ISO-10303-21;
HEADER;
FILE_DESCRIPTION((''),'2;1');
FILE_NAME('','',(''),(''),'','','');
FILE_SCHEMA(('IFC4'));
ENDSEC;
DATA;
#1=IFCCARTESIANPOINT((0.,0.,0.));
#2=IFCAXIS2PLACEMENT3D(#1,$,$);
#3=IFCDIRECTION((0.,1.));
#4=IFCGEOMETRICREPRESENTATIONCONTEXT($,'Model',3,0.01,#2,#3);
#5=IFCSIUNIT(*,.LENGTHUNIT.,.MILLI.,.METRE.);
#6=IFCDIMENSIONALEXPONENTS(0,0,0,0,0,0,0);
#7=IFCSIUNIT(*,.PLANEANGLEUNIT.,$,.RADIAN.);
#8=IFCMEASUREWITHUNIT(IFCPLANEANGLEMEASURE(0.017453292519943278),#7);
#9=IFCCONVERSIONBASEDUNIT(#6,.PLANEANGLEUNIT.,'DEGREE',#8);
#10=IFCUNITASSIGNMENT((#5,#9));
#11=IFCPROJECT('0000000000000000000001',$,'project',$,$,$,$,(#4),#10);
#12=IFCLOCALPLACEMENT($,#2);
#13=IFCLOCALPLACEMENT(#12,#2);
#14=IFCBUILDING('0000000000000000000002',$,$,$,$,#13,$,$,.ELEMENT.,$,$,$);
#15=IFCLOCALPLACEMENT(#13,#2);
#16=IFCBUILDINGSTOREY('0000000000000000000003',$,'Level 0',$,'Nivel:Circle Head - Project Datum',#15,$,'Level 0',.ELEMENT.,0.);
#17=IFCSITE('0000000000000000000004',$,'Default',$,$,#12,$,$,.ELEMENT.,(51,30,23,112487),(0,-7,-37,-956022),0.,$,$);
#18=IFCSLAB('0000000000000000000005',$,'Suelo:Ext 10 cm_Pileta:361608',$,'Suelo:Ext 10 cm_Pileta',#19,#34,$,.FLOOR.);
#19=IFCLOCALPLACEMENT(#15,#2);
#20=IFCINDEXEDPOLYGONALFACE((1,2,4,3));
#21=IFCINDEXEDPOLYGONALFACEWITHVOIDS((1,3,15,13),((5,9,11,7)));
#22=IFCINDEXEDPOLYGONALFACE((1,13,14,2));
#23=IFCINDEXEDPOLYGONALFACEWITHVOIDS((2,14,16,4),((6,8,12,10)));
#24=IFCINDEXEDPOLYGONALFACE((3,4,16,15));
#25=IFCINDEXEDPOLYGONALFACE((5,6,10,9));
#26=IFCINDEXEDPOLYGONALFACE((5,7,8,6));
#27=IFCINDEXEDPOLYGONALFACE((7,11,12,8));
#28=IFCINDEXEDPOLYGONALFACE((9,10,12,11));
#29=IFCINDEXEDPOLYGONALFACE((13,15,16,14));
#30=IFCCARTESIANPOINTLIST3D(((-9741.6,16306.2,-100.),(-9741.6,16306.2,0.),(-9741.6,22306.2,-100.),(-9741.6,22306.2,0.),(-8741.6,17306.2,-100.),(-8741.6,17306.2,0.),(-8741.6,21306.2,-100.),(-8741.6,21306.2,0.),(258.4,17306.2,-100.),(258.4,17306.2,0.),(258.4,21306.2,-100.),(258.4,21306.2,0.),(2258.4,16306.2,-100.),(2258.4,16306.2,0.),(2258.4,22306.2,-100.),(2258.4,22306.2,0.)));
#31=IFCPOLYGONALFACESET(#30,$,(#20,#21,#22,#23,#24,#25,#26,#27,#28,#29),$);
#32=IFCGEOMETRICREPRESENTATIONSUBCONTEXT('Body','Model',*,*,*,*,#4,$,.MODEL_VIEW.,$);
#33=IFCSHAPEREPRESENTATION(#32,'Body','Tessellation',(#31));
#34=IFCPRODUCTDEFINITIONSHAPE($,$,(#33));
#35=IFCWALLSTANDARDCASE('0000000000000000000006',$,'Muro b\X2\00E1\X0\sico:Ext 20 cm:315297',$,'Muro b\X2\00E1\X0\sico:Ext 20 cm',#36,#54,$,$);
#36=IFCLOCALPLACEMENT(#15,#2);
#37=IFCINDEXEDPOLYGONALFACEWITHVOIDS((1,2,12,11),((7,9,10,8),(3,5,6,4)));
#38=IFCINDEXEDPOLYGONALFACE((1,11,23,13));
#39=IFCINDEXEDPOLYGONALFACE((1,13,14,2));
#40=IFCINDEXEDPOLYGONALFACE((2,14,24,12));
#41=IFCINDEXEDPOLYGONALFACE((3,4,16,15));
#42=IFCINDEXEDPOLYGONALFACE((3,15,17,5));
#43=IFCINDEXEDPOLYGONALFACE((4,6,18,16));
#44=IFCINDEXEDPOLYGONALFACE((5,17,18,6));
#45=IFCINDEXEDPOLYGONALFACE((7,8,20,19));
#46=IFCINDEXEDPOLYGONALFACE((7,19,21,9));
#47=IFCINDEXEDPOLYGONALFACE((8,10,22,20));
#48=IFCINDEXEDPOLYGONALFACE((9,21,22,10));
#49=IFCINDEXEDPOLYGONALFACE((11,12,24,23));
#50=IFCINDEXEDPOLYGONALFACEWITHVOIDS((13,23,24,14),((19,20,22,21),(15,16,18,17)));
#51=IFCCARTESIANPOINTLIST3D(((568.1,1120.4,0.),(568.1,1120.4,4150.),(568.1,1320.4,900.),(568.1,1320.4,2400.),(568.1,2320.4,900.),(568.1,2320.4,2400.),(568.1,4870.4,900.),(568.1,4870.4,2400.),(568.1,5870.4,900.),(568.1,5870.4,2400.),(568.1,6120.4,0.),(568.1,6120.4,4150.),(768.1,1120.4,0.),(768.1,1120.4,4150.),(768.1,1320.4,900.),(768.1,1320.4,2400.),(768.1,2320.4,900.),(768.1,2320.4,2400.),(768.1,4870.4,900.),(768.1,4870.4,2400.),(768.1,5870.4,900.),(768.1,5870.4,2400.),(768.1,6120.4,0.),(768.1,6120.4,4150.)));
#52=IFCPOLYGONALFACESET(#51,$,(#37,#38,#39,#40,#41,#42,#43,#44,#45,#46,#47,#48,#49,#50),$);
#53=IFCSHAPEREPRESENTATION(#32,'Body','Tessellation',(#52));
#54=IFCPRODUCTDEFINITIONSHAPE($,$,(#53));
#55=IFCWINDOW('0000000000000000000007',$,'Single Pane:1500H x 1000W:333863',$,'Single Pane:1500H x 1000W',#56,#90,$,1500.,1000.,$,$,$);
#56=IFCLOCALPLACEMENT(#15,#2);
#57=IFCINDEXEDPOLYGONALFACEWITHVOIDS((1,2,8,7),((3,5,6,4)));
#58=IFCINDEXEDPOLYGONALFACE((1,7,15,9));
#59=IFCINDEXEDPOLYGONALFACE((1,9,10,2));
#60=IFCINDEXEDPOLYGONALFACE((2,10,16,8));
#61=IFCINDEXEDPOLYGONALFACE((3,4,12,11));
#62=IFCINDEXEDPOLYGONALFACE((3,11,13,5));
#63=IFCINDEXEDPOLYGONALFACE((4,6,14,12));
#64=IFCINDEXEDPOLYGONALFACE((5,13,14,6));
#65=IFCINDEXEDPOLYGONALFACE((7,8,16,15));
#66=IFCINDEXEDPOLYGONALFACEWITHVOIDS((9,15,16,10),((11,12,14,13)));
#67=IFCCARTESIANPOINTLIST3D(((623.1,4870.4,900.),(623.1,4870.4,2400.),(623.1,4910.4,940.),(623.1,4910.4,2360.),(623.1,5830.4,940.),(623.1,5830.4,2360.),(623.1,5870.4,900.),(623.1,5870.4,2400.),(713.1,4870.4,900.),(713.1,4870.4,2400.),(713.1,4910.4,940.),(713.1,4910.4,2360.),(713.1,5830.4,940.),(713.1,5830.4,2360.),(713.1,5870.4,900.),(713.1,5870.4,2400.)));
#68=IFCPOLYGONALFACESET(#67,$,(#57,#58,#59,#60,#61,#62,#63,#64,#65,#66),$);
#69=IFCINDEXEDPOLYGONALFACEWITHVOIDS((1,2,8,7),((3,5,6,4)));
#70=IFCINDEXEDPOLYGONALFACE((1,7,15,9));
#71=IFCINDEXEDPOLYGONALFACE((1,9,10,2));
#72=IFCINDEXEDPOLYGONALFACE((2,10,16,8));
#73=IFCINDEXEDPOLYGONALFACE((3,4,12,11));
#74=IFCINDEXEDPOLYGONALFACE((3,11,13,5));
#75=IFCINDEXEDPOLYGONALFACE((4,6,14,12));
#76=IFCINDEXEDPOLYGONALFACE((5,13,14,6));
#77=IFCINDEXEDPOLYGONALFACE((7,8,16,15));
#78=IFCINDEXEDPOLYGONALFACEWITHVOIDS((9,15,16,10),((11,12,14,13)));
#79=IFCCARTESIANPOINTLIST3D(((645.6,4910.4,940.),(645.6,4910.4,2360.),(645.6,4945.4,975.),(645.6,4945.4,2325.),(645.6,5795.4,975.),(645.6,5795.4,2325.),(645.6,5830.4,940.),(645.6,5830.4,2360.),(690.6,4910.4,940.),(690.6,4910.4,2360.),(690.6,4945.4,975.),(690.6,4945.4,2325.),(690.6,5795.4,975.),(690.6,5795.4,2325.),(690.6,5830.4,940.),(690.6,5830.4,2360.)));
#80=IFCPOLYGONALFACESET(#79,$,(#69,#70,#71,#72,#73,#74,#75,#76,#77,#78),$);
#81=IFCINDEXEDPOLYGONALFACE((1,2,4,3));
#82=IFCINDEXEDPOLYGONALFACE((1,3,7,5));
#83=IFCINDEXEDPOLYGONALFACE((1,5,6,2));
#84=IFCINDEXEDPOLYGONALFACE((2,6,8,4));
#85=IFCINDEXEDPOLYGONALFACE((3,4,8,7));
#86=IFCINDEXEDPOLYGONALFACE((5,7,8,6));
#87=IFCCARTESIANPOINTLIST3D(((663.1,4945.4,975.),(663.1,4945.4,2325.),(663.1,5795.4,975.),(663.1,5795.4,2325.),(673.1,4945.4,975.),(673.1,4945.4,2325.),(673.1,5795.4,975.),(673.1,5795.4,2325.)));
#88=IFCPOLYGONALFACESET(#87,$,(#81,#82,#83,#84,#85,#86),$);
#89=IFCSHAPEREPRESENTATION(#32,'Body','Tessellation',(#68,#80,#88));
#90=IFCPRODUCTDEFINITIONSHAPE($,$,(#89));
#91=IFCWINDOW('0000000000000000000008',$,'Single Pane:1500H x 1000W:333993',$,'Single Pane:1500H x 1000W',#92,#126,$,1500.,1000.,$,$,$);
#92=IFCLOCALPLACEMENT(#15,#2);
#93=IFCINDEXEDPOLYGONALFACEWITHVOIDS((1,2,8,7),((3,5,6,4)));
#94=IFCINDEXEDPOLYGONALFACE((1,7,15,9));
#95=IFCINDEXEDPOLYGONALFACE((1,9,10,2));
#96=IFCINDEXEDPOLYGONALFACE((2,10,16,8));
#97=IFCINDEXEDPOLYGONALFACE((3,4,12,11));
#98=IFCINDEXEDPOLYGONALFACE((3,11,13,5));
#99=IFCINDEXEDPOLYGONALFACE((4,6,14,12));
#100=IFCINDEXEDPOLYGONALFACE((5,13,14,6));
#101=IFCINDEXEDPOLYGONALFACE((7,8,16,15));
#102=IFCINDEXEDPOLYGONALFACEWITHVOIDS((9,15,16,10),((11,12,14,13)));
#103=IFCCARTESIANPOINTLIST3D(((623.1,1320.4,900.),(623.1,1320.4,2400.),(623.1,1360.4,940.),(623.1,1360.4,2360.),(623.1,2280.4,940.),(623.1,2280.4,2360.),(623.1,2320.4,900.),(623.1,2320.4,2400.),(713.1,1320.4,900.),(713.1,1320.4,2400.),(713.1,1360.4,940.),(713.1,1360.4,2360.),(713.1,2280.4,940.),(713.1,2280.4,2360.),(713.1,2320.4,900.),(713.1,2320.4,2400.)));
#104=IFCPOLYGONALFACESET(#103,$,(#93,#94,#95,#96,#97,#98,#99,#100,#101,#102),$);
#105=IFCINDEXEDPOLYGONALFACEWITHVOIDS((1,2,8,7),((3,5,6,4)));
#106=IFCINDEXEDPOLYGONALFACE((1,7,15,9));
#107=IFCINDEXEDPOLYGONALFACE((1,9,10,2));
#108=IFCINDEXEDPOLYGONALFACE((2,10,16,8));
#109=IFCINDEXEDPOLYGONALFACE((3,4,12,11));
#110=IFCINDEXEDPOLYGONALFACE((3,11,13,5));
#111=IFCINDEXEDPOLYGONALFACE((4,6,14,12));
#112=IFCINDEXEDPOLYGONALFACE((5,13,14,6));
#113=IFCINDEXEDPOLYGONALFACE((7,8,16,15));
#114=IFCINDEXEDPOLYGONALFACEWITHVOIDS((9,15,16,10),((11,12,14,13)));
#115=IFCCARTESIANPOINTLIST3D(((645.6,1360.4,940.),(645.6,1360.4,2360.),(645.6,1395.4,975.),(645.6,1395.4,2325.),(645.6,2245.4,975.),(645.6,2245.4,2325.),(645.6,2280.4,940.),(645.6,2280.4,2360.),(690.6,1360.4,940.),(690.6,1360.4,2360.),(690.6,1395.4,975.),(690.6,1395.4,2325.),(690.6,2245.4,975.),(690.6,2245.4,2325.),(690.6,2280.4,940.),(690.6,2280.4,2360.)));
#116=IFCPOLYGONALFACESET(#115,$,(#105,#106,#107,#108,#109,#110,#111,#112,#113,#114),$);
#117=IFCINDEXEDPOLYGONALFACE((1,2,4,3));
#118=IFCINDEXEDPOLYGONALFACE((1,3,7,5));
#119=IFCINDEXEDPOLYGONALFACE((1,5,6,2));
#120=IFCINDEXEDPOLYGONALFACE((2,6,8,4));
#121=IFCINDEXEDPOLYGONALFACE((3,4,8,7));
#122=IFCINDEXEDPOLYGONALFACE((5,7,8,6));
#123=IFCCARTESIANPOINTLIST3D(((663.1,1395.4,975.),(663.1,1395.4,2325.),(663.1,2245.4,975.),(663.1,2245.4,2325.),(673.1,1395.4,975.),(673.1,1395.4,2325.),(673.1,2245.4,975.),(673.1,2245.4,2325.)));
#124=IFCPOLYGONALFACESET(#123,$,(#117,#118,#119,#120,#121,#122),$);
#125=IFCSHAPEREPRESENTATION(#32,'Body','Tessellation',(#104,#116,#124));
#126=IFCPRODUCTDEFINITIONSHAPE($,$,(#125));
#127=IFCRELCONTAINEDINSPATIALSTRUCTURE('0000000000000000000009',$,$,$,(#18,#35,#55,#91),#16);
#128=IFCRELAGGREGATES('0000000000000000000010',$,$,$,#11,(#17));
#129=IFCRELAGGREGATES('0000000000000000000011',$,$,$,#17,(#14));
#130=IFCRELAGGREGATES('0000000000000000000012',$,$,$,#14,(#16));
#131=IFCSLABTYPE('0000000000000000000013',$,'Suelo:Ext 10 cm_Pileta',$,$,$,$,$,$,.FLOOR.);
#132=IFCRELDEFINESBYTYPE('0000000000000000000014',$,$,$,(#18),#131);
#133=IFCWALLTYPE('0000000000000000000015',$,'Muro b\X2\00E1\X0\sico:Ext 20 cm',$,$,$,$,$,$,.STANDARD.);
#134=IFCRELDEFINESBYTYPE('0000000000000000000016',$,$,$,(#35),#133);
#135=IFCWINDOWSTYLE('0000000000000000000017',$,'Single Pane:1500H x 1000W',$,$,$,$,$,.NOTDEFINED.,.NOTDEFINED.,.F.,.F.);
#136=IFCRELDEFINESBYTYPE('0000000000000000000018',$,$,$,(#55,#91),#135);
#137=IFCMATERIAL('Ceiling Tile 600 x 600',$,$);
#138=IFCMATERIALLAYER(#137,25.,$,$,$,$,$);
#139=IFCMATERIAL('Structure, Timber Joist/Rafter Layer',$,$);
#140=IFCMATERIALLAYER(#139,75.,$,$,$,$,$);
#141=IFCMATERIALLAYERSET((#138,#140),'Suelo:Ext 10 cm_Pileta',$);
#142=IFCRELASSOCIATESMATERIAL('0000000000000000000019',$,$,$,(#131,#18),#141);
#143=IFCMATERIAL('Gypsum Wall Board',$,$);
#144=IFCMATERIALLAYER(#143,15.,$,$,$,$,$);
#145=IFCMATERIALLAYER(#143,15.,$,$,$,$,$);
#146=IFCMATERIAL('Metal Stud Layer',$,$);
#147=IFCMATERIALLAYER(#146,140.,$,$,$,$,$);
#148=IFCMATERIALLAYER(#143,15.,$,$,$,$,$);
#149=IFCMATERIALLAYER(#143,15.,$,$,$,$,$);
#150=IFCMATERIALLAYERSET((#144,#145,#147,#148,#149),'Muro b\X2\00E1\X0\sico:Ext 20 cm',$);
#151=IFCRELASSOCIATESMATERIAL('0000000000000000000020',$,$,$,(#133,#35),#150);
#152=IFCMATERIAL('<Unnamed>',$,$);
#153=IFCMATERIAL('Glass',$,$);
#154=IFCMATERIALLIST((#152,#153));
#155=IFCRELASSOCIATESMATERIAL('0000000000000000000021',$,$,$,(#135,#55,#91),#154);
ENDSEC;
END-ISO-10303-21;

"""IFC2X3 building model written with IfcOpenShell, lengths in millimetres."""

from ifc_helpers import new_model, entity, si_unit, converted_unit, direction, frame, frame_2d, origin, origin_2d_with_axis, place, context, subcontext, project, spatial, polyline, rectangle, outline, extrude, boolean, source, transform, mapped, material, material_list, layer, layer_set, layer_usage, type_object, type_shapes, element, fill, save


model = new_model("IFC2X3")

# Units and contexts
model_context = context("Model", 3, precision=0.01, world=origin(), true_north=direction((0.0, 1.0)))
body_context = subcontext(model_context, "Body", "Model", "MODEL_VIEW")
ifc_project = project(units=[si_unit("LENGTHUNIT", "METRE", prefix="MILLI"), converted_unit("PLANEANGLEUNIT", "DEGREE", entity("IfcPlaneAngleMeasure", 0.017453292519943278), si_unit("PLANEANGLEUNIT", "RADIAN"), dimensions=[0, 0, 0, 0, 0, 0, 0])], contexts=[model_context])

# Site, building, storey
site_placement = place(None, origin())
site = spatial("IfcSite", under=ifc_project, at=site_placement, Name="Default", CompositionType="ELEMENT", RefLatitude=(51, 30, 23, 112487), RefLongitude=(0, -7, -37, -956022), RefElevation=0.0)
building_placement = place(site_placement, origin())
building = spatial("IfcBuilding", under=site, at=building_placement, CompositionType="ELEMENT")
storey_placement = place(building_placement, origin())
storey = spatial("IfcBuildingStorey", under=building, at=storey_placement, Name="Level 0", ObjectType="Nivel:Circle Head - Project Datum", LongName="Level 0", CompositionType="ELEMENT", Elevation=0.0)

# Shared definitions
ifc_material_1 = material(Name="Structure, Timber Joist/Rafter Layer")

# Slab, opening
ifc_material_2 = material(Name="Ceiling Tile 600 x 600")
ifc_layer_1 = layer(ifc_material_2, 25.0)
ifc_layer_2 = layer(ifc_material_1, 75.0)
ifc_layer_set_1 = layer_set([ifc_layer_1, ifc_layer_2], Name="Suelo:Ext 10 cm_Pileta")
ifc_layer_usage_1 = layer_usage(ifc_layer_set_1, "AXIS3", "POSITIVE", 0.0)
slab_type_1 = type_object("IfcSlabType", Name="Suelo:Ext 10 cm_Pileta", PredefinedType="FLOOR", material=ifc_layer_set_1)
slab_1_placement = place(storey_placement, origin())
slab_1 = element("IfcSlab", 1, at=slab_1_placement, inside=storey, type_object=slab_type_1, material=ifc_layer_usage_1, Name="Suelo:Ext 10 cm_Pileta:361608", ObjectType="Suelo:Ext 10 cm_Pileta", PredefinedType="FLOOR", context=body_context, shape_type="SweptSolid", body=[
    boolean("DIFFERENCE", extrude(rectangle(XDim=6000.0, YDim=12000.0, at=origin_2d_with_axis()), frame((-3741.6, 19306.2, 0.0), z_axis=(0.0, 0.0, -1.0), x_axis=(0.0, 1.0, 0.0)), (0.0, 0.0, 1.0), 100.0), extrude(rectangle(XDim=4000.0, YDim=9000.0, at=frame_2d((0.0, 0.0), x_axis=(1.0, 0.0))), frame((-4241.6, 19306.2, -100.0), z_axis=(0.0, 0.0, 1.0), x_axis=(0.0, 1.0, 0.0)), (0.0, 0.0, 1.0), 100.0)),
])
opening_1_placement = place(slab_1_placement, origin())
element("IfcOpeningElement", 2, at=opening_1_placement, cuts=slab_1, ObjectType="Opening", context=body_context, shape_type="SweptSolid", body=[
    extrude(rectangle(XDim=4000.0, YDim=9000.0, at=frame_2d((0.0, 0.0), x_axis=(1.0, 0.0))), frame((-4241.6, 19306.2, 0.0), z_axis=(0.0, 0.0, -1.0), x_axis=(0.0, 1.0, 0.0)), (0.0, 0.0, 1.0), 100.0),
])

# Wall, openings, windows
ifc_material_3 = material(Name="Gypsum Wall Board")
ifc_layer_3 = layer(ifc_material_3, 15.0)
ifc_layer_4 = layer(ifc_material_3, 15.0)
ifc_material_4 = material(Name="Metal Stud Layer")
ifc_layer_5 = layer(ifc_material_4, 140.0)
ifc_layer_6 = layer(ifc_material_3, 15.0)
ifc_layer_7 = layer(ifc_material_3, 15.0)
ifc_layer_set_2 = layer_set([ifc_layer_3, ifc_layer_4, ifc_layer_5, ifc_layer_6, ifc_layer_7], Name="Muro básico:Ext 20 cm")
ifc_layer_usage_2 = layer_usage(ifc_layer_set_2, "AXIS2", "NEGATIVE", 100.0)
wall_type_1 = type_object("IfcWallType", Name="Muro básico:Ext 20 cm", PredefinedType="STANDARD", material=ifc_layer_set_2)
wall_1_placement = place(storey_placement, frame((668.1, 6120.4, 0.0), z_axis=(0.0, 0.0, 1.0), x_axis=(0.0, -1.0, 0.0)))
wall_1 = element("IfcWallStandardCase", 3, at=wall_1_placement, inside=storey, type_object=wall_type_1, material=ifc_layer_usage_2, Name="Muro básico:Ext 20 cm:315297", ObjectType="Muro básico:Ext 20 cm", context=body_context, shape_type="SweptSolid", body=[
    extrude(rectangle(XDim=5000.0, YDim=200.0, at=frame_2d((2500.0, 0.0), x_axis=(-1.0, 0.0))), origin(), (0.0, 0.0, 1.0), 4150.0),
])
opening_2_placement = place(wall_1_placement, frame((250.0, -100.0, 900.0)))
opening_2 = element("IfcOpeningElement", 4, at=opening_2_placement, cuts=wall_1, ObjectType="Opening", context=body_context, shape_type="SweptSolid", body=[
    extrude(rectangle(XDim=1500.0, YDim=1000.0, at=frame_2d((750.0, 500.0), x_axis=(1.0, 0.0))), frame((0.0, 0.0, 0.0), z_axis=(0.0, 1.0, 0.0), x_axis=(0.0, 0.0, 1.0)), (0.0, 0.0, 1.0), 200.0),
])
opening_3_placement = place(wall_1_placement, frame((3800.0, -100.0, 900.0)))
opening_3 = element("IfcOpeningElement", 5, at=opening_3_placement, cuts=wall_1, ObjectType="Opening", context=body_context, shape_type="SweptSolid", body=[
    extrude(rectangle(XDim=1500.0, YDim=1000.0, at=frame_2d((750.0, 500.0), x_axis=(1.0, 0.0))), frame((0.0, 0.0, 0.0), z_axis=(0.0, 1.0, 0.0), x_axis=(0.0, 0.0, 1.0)), (0.0, 0.0, 1.0), 200.0),
])
ifc_material_5 = material(Name="<Unnamed>")
ifc_material_6 = material(Name="Glass")
ifc_material_list_1 = material_list([ifc_material_5, ifc_material_6])
window_style_1 = type_object("IfcWindowStyle", Name="Single Pane:1500H x 1000W", ConstructionType="NOTDEFINED", OperationType="NOTDEFINED", ParameterTakesPrecedence=False, Sizeable=False, material=ifc_material_list_1)
shared_shape_1 = source(origin(), body_context, "Body", "SweptSolid", [
    extrude(outline(polyline([(-500.0, -750.0), (500.0, -750.0), (500.0, 750.0), (-500.0, 750.0), (-500.0, -750.0)]), holes=[polyline([(-460.0, -710.0), (-460.0, 710.0), (460.0, 710.0), (460.0, -710.0), (-460.0, -710.0)])]), frame((500.0, 55.0, 750.0), z_axis=(0.0, 1.0, 0.0), x_axis=(1.0, 0.0, 0.0)), (0.0, 0.0, 1.0), 90.0),
    extrude(outline(polyline([(-460.0, -710.0), (460.0, -710.0), (460.0, 710.0), (-460.0, 710.0), (-460.0, -710.0)]), holes=[polyline([(-425.0, -675.0), (-425.0, 675.0), (425.0, 675.0), (425.0, -675.0), (-425.0, -675.0)])]), frame((500.0, 77.5, 750.0), z_axis=(0.0, 1.0, 0.0), x_axis=(1.0, 0.0, 0.0)), (0.0, 0.0, 1.0), 45.0),
    extrude(rectangle(XDim=10.0, YDim=850.0, at=origin_2d_with_axis()), frame((500.0, 100.0, 75.0), z_axis=(0.0, 0.0, 1.0), x_axis=(0.0, 1.0, 0.0)), (0.0, 0.0, 1.0), 1350.0),
])
type_shapes(window_style_1, [shared_shape_1])
window_1_placement = place(opening_2_placement, origin())
window_1 = element("IfcWindow", 6, at=window_1_placement, inside=storey, type_object=window_style_1, material=ifc_material_list_1, Name="Single Pane:1500H x 1000W:333863", ObjectType="Single Pane:1500H x 1000W", OverallHeight=1500.0, OverallWidth=1000.0, context=body_context, shape_type="MappedRepresentation", body=[
    mapped(shared_shape_1, transform((0.0, 0.0, 0.0), scale=1.0)),
])
fill(opening_2, window_1)
window_2_placement = place(opening_3_placement, origin())
window_2 = element("IfcWindow", 7, at=window_2_placement, inside=storey, type_object=window_style_1, material=ifc_material_list_1, Name="Single Pane:1500H x 1000W:333993", ObjectType="Single Pane:1500H x 1000W", OverallHeight=1500.0, OverallWidth=1000.0, context=body_context, shape_type="MappedRepresentation", body=[
    mapped(shared_shape_1, transform((0.0, 0.0, 0.0), scale=1.0)),
])
fill(opening_3, window_2)

save(model, "model.ifc")
